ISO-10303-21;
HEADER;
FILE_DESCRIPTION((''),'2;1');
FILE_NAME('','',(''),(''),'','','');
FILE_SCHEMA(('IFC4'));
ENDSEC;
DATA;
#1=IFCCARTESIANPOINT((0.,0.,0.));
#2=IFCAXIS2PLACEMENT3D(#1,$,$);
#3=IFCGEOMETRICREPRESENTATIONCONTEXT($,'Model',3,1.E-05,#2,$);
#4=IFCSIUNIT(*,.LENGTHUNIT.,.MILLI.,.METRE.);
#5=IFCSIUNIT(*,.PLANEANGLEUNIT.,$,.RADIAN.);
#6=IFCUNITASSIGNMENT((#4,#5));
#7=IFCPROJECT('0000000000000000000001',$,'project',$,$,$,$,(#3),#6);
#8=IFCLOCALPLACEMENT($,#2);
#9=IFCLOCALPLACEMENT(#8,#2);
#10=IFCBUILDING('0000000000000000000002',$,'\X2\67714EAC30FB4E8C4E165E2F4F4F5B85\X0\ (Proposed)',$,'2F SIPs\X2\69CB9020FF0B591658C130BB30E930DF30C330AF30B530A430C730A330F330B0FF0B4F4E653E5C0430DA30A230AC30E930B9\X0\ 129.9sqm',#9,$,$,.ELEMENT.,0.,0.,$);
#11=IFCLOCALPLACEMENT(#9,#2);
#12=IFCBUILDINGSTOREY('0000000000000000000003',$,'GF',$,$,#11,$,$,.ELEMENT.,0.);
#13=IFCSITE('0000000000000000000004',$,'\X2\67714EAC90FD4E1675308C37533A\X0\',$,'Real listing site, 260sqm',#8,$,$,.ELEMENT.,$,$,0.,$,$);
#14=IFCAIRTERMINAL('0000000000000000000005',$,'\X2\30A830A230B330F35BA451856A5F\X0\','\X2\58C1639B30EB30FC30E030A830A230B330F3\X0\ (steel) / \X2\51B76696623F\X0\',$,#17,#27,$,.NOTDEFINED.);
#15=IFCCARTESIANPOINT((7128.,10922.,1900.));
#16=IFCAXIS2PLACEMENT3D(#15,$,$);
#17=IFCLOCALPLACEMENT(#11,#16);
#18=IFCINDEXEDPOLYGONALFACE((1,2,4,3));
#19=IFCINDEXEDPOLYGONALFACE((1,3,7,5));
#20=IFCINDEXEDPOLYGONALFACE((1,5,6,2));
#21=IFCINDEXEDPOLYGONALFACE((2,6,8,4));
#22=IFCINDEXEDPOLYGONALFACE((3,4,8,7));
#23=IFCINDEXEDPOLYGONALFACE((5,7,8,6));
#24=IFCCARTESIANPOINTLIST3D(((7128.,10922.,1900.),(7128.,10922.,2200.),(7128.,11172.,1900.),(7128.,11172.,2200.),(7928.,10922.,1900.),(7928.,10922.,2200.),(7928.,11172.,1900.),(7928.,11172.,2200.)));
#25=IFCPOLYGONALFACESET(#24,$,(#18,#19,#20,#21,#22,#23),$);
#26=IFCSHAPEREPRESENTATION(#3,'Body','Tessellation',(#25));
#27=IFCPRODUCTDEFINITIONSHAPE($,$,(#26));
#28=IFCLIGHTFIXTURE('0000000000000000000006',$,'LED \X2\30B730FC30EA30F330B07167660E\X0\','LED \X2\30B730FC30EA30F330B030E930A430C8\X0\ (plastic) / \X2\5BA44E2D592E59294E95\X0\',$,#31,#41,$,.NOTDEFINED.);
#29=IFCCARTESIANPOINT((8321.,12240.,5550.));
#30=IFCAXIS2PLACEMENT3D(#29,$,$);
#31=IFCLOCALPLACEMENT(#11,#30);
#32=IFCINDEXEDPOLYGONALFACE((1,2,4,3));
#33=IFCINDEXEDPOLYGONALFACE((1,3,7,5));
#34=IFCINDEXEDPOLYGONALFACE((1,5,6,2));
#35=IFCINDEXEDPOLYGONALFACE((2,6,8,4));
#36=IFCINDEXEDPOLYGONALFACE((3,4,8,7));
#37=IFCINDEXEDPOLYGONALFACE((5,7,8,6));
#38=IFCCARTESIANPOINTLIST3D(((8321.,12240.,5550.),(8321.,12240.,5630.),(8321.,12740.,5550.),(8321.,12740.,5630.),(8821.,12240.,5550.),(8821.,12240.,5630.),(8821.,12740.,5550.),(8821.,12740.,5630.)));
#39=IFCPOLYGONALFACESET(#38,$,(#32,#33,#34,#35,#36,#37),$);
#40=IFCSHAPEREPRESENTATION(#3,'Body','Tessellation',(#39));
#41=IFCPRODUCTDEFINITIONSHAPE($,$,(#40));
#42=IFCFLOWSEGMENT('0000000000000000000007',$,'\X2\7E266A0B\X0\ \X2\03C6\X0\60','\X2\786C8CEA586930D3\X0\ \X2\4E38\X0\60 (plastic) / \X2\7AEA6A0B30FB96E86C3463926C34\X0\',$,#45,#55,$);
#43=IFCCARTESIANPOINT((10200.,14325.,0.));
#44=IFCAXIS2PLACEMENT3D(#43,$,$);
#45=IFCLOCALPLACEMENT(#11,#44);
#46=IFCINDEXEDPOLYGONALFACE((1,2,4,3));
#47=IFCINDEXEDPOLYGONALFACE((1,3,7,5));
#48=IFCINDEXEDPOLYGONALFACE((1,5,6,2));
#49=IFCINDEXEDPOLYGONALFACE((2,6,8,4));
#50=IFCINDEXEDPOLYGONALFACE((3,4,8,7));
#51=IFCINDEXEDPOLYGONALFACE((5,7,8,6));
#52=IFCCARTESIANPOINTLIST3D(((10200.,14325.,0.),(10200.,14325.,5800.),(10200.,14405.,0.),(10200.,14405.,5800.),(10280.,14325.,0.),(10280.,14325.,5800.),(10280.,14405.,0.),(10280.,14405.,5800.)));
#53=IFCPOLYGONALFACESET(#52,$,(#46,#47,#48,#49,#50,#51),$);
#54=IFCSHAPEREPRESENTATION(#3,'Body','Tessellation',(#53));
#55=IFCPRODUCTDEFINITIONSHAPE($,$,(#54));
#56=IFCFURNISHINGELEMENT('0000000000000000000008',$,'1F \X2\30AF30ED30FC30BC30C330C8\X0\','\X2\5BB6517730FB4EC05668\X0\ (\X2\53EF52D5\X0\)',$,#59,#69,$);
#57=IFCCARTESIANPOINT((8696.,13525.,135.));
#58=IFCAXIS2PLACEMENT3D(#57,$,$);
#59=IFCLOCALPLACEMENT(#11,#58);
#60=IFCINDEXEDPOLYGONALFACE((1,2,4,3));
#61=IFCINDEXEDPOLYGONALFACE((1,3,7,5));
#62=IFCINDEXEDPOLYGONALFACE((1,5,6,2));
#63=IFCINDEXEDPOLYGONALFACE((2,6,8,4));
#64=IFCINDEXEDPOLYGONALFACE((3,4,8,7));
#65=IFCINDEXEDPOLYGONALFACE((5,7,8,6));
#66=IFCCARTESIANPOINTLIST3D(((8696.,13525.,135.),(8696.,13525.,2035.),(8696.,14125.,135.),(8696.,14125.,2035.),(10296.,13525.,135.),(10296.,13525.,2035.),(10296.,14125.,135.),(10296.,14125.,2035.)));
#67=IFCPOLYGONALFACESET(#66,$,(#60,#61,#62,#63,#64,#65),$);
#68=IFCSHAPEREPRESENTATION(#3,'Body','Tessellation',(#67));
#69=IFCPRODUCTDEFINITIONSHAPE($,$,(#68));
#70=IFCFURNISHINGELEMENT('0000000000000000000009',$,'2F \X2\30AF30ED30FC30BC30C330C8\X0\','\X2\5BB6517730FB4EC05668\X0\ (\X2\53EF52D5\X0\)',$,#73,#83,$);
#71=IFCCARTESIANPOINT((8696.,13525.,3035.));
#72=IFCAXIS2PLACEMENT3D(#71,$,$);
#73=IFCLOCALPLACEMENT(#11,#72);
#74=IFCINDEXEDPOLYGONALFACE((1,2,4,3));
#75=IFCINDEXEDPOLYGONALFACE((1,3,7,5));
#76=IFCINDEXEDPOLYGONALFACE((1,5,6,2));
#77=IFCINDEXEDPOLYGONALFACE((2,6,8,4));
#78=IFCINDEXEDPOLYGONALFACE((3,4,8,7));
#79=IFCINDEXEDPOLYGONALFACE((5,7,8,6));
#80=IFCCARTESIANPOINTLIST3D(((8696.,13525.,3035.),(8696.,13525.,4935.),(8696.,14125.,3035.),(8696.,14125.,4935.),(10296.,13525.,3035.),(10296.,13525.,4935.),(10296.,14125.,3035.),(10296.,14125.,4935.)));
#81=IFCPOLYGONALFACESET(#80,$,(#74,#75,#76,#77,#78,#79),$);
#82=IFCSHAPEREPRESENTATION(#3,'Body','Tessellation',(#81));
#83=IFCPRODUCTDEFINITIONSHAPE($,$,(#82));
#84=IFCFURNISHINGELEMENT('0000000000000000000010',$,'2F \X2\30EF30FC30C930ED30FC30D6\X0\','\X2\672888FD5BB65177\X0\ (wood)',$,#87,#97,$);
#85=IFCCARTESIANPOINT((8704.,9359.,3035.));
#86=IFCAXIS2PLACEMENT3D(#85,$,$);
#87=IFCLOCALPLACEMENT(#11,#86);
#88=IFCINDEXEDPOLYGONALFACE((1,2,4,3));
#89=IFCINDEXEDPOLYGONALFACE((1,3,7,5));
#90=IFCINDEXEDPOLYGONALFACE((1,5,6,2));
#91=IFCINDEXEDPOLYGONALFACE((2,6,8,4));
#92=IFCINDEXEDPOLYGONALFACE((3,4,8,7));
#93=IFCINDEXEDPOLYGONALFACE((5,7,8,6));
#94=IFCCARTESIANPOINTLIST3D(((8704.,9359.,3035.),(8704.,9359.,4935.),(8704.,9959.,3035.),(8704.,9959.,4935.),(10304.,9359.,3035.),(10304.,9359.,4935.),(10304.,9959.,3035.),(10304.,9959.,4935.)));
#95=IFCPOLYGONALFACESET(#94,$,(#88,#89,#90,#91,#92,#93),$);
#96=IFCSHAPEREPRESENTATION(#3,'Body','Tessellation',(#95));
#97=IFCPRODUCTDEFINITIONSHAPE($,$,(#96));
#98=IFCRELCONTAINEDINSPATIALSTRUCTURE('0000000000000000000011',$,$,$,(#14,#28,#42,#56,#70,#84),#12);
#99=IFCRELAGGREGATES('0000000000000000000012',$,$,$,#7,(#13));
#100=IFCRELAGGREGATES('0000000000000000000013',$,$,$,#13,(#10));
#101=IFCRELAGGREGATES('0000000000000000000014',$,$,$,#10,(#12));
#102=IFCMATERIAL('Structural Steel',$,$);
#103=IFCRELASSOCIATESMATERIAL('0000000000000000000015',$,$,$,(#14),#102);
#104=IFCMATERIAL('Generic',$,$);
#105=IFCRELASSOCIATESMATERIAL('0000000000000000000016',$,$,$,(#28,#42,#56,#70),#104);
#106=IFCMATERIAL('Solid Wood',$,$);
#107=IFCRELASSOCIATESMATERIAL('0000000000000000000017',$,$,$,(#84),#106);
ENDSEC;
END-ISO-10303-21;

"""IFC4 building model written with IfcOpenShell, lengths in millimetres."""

from ifc_helpers import new_model, si_unit, frame, frame_2d, origin, place, context, project, spatial, rectangle, extrude, material, element, save


model = new_model("IFC4")

# Units and contexts
model_context = context("Model", 3, precision=1e-05, world=origin())
ifc_project = project(units=[si_unit("LENGTHUNIT", "METRE", prefix="MILLI"), si_unit("PLANEANGLEUNIT", "RADIAN")], contexts=[model_context])

# Site, building, storey
site_placement = place(None, origin())
site = spatial("IfcSite", under=ifc_project, at=site_placement, Name="東京都世田谷区", ObjectType="Real listing site, 260sqm", CompositionType="ELEMENT", RefElevation=0.0)
building_placement = place(site_placement, origin())
building = spatial("IfcBuilding", under=site, at=building_placement, Name="東京・二世帯住宅 (Proposed)", ObjectType="2F SIPs構造＋外壁セラミックサイディング＋低放射ペアガラス 129.9sqm", CompositionType="ELEMENT", ElevationOfRefHeight=0.0, ElevationOfTerrain=0.0)
storey_placement = place(building_placement, origin())
storey = spatial("IfcBuildingStorey", under=building, at=storey_placement, Name="GF", CompositionType="ELEMENT", Elevation=0.0)

# Shared definitions
ifc_material_1 = material(Name="Solid Wood")

# Shared definitions
ifc_material_2 = material(Name="Structural Steel")

# Shared definitions
ifc_material_3 = material(Name="Generic")

# Air terminal
air_terminal_placement = place(storey_placement, frame((7128.0, 10922.0, 1900.0)))
element("IfcAirTerminal", 1, at=air_terminal_placement, inside=storey, material=ifc_material_2, Name="エアコン室内機", Description="壁掛ルームエアコン (steel) / 冷暖房", PredefinedType="NOTDEFINED", context=model_context, shape_type="SweptSolid", body=[
    extrude(rectangle(XDim=800.0, YDim=250.0, at=frame_2d((400.0, 125.0))), frame((7128.0, 10922.0, 1900.0)), (0.0, 0.0, 1.0), 300.0),
])

# Light fixture
light_fixture_1_placement = place(storey_placement, frame((8321.0, 12240.0, 5550.0)))
element("IfcLightFixture", 2, at=light_fixture_1_placement, inside=storey, material=ifc_material_3, Name="LED シーリング照明", Description="LED シーリングライト (plastic) / 室中央天井", PredefinedType="NOTDEFINED", context=model_context, shape_type="SweptSolid", body=[
    extrude(rectangle(XDim=500.0, YDim=500.0, at=frame_2d((250.0, 250.0))), frame((8321.0, 12240.0, 5550.0)), (0.0, 0.0, 1.0), 80.0),
])

# Flow segment
flow_segment_placement = place(storey_placement, frame((10200.0, 14325.0, 0.0)))
element("IfcFlowSegment", 3, at=flow_segment_placement, inside=storey, material=ifc_material_3, Name="縦樋 φ60", Description="硬質塩ビ 丸60 (plastic) / 竪樋・雨水排水", context=model_context, shape_type="SweptSolid", body=[
    extrude(rectangle(XDim=80.0, YDim=80.0, at=frame_2d((40.0, 40.0))), frame((10200.0, 14325.0, 0.0)), (0.0, 0.0, 1.0), 5800.0),
])

# Furnishing elements
furnishing_1_placement = place(storey_placement, frame((8696.0, 13525.0, 135.0)))
element("IfcFurnishingElement", 4, at=furnishing_1_placement, inside=storey, material=ifc_material_3, Name="1F クローゼット", Description="家具・什器 (可動)", context=model_context, shape_type="SweptSolid", body=[
    extrude(rectangle(XDim=1600.0, YDim=600.0, at=frame_2d((800.0, 300.0))), frame((8696.0, 13525.0, 135.0)), (0.0, 0.0, 1.0), 1900.0),
])
furnishing_2_placement = place(storey_placement, frame((8696.0, 13525.0, 3035.0)))
element("IfcFurnishingElement", 5, at=furnishing_2_placement, inside=storey, material=ifc_material_3, Name="2F クローゼット", Description="家具・什器 (可動)", context=model_context, shape_type="SweptSolid", body=[
    extrude(rectangle(XDim=1600.0, YDim=600.0, at=frame_2d((800.0, 300.0))), frame((8696.0, 13525.0, 3035.0)), (0.0, 0.0, 1.0), 1900.0),
])
furnishing_3_placement = place(storey_placement, frame((8704.0, 9359.0, 3035.0)))
element("IfcFurnishingElement", 6, at=furnishing_3_placement, inside=storey, material=ifc_material_1, Name="2F ワードローブ", Description="木製家具 (wood)", context=model_context, shape_type="SweptSolid", body=[
    extrude(rectangle(XDim=1600.0, YDim=600.0, at=frame_2d((800.0, 300.0))), frame((8704.0, 9359.0, 3035.0)), (0.0, 0.0, 1.0), 1900.0),
])

save(model, "model.ifc")
